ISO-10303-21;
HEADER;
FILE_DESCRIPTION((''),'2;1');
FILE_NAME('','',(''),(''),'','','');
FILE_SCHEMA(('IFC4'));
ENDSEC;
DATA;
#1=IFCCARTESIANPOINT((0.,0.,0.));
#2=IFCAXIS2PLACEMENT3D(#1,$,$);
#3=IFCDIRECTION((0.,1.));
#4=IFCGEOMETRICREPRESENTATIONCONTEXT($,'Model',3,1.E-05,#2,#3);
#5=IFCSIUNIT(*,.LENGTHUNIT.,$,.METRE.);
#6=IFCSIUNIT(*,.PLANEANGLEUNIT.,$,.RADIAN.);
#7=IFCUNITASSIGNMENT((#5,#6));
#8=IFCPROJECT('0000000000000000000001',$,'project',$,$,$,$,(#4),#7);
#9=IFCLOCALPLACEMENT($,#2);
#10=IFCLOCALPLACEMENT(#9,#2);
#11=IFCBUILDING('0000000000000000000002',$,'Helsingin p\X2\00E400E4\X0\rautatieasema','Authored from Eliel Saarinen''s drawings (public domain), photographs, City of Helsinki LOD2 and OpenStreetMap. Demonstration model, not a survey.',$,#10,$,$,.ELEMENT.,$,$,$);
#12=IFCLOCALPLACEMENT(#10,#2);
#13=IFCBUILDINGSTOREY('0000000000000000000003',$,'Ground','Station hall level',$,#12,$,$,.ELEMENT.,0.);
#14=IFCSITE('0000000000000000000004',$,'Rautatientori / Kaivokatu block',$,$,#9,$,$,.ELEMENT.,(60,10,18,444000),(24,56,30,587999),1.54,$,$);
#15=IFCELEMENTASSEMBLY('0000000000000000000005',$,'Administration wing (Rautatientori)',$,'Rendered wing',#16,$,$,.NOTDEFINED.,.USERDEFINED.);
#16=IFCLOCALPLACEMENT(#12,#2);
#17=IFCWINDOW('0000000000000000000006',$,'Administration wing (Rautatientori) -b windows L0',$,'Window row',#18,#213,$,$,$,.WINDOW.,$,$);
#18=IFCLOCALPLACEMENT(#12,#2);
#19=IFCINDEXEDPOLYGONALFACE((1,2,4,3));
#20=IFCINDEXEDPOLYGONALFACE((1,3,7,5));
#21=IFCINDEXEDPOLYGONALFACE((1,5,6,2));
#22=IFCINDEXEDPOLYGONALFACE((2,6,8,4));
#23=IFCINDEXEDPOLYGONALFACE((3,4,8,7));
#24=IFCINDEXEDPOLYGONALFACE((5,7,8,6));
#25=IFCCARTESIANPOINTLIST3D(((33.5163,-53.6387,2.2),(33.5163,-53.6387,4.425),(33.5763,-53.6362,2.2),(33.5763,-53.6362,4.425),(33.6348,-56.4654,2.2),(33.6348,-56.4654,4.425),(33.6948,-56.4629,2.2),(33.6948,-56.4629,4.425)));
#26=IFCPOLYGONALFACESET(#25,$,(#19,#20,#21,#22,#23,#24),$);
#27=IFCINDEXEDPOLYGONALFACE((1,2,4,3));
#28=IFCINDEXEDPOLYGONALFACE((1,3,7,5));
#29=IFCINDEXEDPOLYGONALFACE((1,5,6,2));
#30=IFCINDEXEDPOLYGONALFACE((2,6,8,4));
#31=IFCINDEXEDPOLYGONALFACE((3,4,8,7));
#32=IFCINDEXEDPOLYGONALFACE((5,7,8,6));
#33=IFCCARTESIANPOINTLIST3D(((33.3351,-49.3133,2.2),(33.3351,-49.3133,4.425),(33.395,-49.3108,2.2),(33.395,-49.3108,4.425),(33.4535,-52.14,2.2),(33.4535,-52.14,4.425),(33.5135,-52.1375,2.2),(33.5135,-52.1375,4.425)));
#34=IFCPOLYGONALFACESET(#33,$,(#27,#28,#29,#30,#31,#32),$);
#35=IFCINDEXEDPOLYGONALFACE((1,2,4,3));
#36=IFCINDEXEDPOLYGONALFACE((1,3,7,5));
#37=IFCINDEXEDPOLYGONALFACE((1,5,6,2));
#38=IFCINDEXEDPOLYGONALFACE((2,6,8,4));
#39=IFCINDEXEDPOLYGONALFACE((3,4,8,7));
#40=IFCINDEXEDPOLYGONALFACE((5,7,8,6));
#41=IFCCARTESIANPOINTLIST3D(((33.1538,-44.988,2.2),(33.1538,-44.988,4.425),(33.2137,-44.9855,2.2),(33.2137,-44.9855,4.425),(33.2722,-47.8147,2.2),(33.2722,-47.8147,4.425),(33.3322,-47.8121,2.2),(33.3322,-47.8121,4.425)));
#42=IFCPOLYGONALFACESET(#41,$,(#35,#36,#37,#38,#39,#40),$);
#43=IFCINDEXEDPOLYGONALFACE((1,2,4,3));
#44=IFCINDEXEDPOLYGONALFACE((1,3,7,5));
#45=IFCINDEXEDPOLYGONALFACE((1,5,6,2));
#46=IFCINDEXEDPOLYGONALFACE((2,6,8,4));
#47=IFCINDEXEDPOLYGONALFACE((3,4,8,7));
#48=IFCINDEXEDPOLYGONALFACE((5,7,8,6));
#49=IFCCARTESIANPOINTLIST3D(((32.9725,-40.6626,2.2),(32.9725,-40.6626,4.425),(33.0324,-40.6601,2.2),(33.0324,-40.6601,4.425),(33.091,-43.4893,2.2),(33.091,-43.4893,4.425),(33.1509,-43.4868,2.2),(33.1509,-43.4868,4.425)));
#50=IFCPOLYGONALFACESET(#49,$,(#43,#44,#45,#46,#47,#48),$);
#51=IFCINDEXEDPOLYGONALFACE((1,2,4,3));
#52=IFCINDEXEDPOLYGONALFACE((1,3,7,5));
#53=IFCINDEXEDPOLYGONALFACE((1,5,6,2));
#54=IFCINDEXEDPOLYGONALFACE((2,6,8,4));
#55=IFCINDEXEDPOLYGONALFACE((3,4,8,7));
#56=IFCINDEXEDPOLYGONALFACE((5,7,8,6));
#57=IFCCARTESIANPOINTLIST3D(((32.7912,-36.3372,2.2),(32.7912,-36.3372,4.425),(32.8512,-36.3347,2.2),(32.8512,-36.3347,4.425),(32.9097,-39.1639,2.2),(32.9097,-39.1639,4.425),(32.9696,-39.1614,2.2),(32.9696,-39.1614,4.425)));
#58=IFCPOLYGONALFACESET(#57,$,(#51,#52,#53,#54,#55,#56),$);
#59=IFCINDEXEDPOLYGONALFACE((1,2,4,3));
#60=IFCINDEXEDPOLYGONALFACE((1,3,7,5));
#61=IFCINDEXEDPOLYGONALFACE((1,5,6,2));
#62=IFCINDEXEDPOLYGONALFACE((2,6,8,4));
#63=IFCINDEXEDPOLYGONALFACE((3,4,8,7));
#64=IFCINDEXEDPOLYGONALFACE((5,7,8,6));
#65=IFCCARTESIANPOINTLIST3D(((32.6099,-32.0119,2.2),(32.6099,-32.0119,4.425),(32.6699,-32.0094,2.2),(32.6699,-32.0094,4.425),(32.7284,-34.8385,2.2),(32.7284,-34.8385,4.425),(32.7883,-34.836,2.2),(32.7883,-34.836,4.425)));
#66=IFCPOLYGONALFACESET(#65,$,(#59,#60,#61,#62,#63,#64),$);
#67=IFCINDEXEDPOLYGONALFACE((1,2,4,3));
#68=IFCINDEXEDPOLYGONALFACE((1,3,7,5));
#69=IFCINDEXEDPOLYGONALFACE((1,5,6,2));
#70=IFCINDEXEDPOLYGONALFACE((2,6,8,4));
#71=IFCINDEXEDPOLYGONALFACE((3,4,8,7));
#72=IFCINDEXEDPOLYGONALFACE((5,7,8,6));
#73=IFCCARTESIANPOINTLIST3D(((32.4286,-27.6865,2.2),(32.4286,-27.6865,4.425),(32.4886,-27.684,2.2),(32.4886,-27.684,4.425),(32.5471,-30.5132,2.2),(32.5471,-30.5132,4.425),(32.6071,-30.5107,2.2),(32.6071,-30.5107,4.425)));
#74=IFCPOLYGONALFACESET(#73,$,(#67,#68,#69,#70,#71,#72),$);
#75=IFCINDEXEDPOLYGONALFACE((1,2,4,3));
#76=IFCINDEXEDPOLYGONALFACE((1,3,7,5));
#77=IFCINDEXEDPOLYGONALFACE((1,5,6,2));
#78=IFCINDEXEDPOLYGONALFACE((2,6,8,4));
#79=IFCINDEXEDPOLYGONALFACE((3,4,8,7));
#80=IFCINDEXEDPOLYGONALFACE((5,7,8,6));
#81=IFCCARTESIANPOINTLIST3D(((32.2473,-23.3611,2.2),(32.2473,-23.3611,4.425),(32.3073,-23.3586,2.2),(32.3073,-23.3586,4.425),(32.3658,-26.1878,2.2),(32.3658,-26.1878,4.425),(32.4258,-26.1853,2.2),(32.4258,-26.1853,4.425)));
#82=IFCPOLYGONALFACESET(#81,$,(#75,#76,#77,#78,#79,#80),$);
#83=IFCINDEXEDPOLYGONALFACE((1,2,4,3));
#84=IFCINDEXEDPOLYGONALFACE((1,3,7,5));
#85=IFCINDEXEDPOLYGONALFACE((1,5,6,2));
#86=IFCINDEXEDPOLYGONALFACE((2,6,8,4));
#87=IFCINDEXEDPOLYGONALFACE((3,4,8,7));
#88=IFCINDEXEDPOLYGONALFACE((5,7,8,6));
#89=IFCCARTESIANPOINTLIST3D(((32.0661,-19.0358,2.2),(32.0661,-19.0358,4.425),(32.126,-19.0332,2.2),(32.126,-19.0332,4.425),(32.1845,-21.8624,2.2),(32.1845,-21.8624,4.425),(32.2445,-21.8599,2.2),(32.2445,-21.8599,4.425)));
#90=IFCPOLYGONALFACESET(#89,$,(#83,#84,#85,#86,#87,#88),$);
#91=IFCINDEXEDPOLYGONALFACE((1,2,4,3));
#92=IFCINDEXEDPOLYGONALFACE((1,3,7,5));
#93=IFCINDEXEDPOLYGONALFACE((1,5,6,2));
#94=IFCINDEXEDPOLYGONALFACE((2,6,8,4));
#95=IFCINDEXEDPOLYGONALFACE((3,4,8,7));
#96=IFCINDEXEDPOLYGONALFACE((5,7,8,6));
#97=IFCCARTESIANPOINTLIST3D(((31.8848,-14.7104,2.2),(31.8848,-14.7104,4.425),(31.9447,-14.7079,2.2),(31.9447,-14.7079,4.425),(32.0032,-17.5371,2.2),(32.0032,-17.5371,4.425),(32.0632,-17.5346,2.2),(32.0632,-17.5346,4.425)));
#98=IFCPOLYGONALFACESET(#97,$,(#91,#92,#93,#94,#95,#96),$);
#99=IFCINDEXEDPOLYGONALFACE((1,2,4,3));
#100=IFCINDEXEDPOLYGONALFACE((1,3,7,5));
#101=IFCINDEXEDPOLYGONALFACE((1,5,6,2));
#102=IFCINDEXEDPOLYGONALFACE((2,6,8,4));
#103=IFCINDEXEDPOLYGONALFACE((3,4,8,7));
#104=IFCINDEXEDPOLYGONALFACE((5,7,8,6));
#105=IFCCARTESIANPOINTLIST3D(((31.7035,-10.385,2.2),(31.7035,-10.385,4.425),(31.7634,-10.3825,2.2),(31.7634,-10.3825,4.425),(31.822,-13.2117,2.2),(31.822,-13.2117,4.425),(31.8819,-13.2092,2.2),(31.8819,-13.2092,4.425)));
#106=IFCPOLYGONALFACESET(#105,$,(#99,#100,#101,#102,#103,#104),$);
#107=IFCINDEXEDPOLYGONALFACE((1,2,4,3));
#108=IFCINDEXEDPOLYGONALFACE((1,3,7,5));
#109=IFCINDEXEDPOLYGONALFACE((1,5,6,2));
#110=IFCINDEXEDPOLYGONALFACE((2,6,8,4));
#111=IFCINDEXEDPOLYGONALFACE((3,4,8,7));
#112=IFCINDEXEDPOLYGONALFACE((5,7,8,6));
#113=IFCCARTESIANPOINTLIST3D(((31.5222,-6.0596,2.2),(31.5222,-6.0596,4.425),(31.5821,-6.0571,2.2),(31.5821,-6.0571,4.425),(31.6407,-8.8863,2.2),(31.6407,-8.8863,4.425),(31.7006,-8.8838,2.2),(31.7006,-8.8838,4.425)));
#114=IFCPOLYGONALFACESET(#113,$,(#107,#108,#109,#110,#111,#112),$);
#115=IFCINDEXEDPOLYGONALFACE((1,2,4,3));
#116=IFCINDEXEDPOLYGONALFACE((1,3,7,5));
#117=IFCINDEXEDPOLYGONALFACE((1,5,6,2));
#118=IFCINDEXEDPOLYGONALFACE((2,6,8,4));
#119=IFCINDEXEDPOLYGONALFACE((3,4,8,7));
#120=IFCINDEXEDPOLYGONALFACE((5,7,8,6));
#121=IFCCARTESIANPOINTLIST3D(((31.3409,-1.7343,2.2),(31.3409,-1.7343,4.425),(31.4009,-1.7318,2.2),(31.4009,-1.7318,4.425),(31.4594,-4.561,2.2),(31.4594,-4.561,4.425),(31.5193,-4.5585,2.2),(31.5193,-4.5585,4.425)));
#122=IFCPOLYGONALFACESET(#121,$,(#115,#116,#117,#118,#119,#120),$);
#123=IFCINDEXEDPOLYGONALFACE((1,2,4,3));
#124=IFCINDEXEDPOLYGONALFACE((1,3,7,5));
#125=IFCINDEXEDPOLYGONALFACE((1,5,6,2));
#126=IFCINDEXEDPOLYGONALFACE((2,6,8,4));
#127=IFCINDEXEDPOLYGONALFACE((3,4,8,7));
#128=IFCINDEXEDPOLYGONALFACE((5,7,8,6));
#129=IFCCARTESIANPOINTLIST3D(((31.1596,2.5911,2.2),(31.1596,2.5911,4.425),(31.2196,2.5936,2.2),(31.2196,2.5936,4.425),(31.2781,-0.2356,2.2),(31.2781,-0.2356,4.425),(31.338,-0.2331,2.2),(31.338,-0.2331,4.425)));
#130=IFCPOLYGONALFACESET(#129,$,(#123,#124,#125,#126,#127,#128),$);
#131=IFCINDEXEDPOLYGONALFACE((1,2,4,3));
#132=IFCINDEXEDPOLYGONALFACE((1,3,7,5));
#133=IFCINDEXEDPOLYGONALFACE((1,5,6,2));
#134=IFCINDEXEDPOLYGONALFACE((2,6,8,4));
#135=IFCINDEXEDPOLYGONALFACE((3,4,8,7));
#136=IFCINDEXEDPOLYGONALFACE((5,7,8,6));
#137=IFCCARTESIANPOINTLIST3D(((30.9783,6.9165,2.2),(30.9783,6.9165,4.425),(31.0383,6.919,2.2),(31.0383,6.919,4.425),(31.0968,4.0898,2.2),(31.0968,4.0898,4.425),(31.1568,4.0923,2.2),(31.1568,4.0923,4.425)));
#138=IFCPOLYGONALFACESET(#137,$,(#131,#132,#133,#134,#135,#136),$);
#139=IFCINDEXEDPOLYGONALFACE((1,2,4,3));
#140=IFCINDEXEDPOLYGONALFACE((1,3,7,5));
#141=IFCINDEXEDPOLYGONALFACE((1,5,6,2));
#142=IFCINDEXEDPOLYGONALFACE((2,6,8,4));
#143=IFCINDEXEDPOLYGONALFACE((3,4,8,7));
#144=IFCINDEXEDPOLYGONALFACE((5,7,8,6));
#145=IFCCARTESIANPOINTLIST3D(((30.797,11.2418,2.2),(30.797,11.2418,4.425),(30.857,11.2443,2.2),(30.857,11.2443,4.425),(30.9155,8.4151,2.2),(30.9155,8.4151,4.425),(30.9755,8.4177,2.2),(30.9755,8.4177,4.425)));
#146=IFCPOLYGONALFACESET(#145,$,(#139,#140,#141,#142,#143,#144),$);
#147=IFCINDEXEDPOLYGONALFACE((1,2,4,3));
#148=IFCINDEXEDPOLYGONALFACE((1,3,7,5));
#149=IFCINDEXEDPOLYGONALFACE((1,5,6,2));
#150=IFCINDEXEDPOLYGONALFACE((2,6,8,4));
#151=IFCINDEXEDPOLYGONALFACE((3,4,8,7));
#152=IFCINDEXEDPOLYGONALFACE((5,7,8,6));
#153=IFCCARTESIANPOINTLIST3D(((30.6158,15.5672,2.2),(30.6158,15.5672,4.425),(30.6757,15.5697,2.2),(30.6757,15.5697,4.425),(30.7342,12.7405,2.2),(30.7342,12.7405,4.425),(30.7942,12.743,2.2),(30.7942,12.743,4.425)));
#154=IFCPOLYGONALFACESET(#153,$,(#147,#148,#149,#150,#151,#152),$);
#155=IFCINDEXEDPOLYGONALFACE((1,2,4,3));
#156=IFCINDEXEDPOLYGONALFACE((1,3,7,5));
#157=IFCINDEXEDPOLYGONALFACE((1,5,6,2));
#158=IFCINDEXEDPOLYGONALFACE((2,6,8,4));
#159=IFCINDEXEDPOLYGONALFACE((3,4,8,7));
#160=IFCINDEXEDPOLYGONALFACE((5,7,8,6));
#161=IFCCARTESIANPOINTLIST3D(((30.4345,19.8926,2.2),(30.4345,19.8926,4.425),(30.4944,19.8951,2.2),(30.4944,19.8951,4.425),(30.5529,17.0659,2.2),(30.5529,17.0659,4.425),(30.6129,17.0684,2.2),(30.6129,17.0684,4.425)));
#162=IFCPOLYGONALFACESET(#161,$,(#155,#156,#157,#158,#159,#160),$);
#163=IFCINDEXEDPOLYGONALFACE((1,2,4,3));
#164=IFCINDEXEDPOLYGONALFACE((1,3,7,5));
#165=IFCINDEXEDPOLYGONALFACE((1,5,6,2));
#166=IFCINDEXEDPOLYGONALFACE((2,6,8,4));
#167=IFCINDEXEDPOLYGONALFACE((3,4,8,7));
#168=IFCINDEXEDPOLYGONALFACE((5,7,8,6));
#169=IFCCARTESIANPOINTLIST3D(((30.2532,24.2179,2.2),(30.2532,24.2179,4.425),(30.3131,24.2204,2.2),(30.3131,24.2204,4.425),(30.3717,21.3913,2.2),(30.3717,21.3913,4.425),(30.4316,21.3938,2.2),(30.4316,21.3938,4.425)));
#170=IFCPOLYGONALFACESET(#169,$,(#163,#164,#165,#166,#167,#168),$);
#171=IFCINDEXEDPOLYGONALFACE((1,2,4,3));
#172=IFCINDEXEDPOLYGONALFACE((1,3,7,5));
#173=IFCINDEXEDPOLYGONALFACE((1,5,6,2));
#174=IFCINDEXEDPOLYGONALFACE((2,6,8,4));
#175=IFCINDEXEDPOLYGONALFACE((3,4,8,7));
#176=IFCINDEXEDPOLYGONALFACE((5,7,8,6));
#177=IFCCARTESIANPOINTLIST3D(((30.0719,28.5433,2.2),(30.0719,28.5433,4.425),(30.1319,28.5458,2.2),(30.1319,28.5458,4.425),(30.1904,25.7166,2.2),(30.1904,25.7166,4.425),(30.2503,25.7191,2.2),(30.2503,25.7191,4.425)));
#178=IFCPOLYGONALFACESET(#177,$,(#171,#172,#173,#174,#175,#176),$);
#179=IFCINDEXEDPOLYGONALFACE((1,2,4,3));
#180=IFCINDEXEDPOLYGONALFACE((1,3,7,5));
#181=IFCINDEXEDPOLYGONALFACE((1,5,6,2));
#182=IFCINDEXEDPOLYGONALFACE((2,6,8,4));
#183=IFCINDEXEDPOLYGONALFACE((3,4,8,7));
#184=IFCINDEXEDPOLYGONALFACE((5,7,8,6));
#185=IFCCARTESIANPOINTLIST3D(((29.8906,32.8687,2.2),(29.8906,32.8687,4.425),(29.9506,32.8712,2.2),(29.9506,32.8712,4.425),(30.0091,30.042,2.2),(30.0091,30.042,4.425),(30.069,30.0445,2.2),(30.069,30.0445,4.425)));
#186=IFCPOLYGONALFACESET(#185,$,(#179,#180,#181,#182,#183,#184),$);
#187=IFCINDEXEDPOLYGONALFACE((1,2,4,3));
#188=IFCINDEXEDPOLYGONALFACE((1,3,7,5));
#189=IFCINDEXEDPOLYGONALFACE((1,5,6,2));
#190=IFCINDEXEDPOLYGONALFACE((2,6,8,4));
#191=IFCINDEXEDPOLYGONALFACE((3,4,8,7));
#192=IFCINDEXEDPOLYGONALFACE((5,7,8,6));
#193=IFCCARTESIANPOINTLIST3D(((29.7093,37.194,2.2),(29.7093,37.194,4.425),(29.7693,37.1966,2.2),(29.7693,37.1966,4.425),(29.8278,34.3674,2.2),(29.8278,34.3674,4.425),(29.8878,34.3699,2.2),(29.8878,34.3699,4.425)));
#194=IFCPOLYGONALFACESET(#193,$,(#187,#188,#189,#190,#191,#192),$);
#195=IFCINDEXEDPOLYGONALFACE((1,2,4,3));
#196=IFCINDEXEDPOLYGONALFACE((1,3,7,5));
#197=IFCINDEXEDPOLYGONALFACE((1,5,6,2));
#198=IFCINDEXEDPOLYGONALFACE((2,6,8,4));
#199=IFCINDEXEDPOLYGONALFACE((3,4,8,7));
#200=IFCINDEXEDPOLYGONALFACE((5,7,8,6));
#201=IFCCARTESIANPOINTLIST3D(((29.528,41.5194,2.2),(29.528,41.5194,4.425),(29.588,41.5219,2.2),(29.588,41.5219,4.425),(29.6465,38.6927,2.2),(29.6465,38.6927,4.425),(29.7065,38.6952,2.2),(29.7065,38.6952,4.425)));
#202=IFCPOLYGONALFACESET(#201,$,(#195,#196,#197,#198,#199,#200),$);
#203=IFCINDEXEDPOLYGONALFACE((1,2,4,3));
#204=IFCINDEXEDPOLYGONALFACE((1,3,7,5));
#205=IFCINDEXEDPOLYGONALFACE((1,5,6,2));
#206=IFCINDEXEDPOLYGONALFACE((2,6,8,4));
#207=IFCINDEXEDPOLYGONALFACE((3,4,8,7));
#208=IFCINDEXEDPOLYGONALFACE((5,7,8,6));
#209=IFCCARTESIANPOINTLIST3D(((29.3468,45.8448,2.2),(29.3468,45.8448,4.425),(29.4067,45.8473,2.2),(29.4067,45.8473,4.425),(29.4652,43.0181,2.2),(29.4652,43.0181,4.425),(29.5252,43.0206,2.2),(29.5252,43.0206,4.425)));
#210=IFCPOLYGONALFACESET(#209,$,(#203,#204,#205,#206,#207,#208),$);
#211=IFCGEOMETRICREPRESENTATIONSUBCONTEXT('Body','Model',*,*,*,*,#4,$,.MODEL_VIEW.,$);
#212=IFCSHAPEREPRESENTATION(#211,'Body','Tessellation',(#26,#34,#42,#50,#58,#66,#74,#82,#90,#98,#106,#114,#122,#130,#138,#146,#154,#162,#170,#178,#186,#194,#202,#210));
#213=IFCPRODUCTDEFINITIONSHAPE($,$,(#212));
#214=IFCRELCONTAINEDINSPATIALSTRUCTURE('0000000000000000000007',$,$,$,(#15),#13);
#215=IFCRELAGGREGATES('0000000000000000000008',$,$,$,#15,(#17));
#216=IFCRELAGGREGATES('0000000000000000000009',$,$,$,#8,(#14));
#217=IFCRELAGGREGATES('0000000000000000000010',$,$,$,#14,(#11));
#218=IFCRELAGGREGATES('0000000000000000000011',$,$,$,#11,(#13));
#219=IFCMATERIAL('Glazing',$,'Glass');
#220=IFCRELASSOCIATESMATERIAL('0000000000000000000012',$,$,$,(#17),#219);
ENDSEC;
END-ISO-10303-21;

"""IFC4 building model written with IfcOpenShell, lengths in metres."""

from ifc_helpers import new_model, si_unit, direction, frame, frame_2d, origin, place, context, subcontext, project, spatial, rectangle, extrude, material, element, aggregate, save


model = new_model("IFC4")

# Units and contexts
model_context = context("Model", 3, precision=1e-05, world=origin(), true_north=direction((0.0, 1.0)))
body_context = subcontext(model_context, "Body", "Model", "MODEL_VIEW")
ifc_project = project(units=[si_unit("LENGTHUNIT", "METRE"), si_unit("PLANEANGLEUNIT", "RADIAN")], contexts=[model_context])

# Site, building, storey
site_placement = place(None, origin())
site = spatial("IfcSite", under=ifc_project, at=site_placement, Name="Rautatientori / Kaivokatu block", CompositionType="ELEMENT", RefLatitude=(60, 10, 18, 444000), RefLongitude=(24, 56, 30, 587999), RefElevation=1.54)
building_placement = place(site_placement, origin())
building = spatial("IfcBuilding", under=site, at=building_placement, Name="Helsingin päärautatieasema", Description="Authored from Eliel Saarinen's drawings (public domain), photographs, City of Helsinki LOD2 and OpenStreetMap. Demonstration model, not a survey.", CompositionType="ELEMENT")
storey_placement = place(building_placement, origin())
storey = spatial("IfcBuildingStorey", under=building, at=storey_placement, Name="Ground", Description="Station hall level", CompositionType="ELEMENT", Elevation=0.0)

# Element assembly, window
assembly_placement = place(building_placement, origin())
assembly = element("IfcElementAssembly", 1, at=assembly_placement, inside=storey, Name="Administration wing (Rautatientori)", ObjectType="Rendered wing", AssemblyPlace="NOTDEFINED", PredefinedType="USERDEFINED")
ifc_material_1 = material(Name="Glazing", Category="Glass")
window_1_placement = place(building_placement, origin())
window_1 = element("IfcWindow", 2, at=window_1_placement, material=ifc_material_1, Name="Administration wing (Rautatientori) -b windows L0", ObjectType="Window row", PredefinedType="WINDOW", context=body_context, shape_type="SweptSolid", body=[
    extrude(rectangle(XDim=2.8292, YDim=0.06, at=frame_2d((0.0, 0.0), x_axis=(-0.041876, 0.999123))), frame((33.6056, -55.0508, 2.2)), (0.0, 0.0, 1.0), 2.225),
    extrude(rectangle(XDim=2.8292, YDim=0.06, at=frame_2d((0.0, 0.0), x_axis=(-0.041876, 0.999123))), frame((33.4243, -50.7254, 2.2)), (0.0, 0.0, 1.0), 2.225),
    extrude(rectangle(XDim=2.8292, YDim=0.06, at=frame_2d((0.0, 0.0), x_axis=(-0.041876, 0.999123))), frame((33.243, -46.4001, 2.2)), (0.0, 0.0, 1.0), 2.225),
    extrude(rectangle(XDim=2.8292, YDim=0.06, at=frame_2d((0.0, 0.0), x_axis=(-0.041876, 0.999123))), frame((33.0617, -42.0747, 2.2)), (0.0, 0.0, 1.0), 2.225),
    extrude(rectangle(XDim=2.8292, YDim=0.06, at=frame_2d((0.0, 0.0), x_axis=(-0.041876, 0.999123))), frame((32.8804, -37.7493, 2.2)), (0.0, 0.0, 1.0), 2.225),
    extrude(rectangle(XDim=2.8292, YDim=0.06, at=frame_2d((0.0, 0.0), x_axis=(-0.041876, 0.999123))), frame((32.6991, -33.4239, 2.2)), (0.0, 0.0, 1.0), 2.225),
    extrude(rectangle(XDim=2.8292, YDim=0.06, at=frame_2d((0.0, 0.0), x_axis=(-0.041876, 0.999123))), frame((32.5178, -29.0986, 2.2)), (0.0, 0.0, 1.0), 2.225),
    extrude(rectangle(XDim=2.8292, YDim=0.06, at=frame_2d((0.0, 0.0), x_axis=(-0.041876, 0.999123))), frame((32.3366, -24.7732, 2.2)), (0.0, 0.0, 1.0), 2.225),
    extrude(rectangle(XDim=2.8292, YDim=0.06, at=frame_2d((0.0, 0.0), x_axis=(-0.041876, 0.999123))), frame((32.1553, -20.4478, 2.2)), (0.0, 0.0, 1.0), 2.225),
    extrude(rectangle(XDim=2.8292, YDim=0.06, at=frame_2d((0.0, 0.0), x_axis=(-0.041876, 0.999123))), frame((31.974, -16.1225, 2.2)), (0.0, 0.0, 1.0), 2.225),
    extrude(rectangle(XDim=2.8292, YDim=0.06, at=frame_2d((0.0, 0.0), x_axis=(-0.041876, 0.999123))), frame((31.7927, -11.7971, 2.2)), (0.0, 0.0, 1.0), 2.225),
    extrude(rectangle(XDim=2.8292, YDim=0.06, at=frame_2d((0.0, 0.0), x_axis=(-0.041876, 0.999123))), frame((31.6114, -7.4717, 2.2)), (0.0, 0.0, 1.0), 2.225),
    extrude(rectangle(XDim=2.8292, YDim=0.06, at=frame_2d((0.0, 0.0), x_axis=(-0.041876, 0.999123))), frame((31.4301, -3.1464, 2.2)), (0.0, 0.0, 1.0), 2.225),
    extrude(rectangle(XDim=2.8292, YDim=0.06, at=frame_2d((0.0, 0.0), x_axis=(-0.041876, 0.999123))), frame((31.2488, 1.179, 2.2)), (0.0, 0.0, 1.0), 2.225),
    extrude(rectangle(XDim=2.8292, YDim=0.06, at=frame_2d((0.0, 0.0), x_axis=(-0.041876, 0.999123))), frame((31.0675, 5.5044, 2.2)), (0.0, 0.0, 1.0), 2.225),
    extrude(rectangle(XDim=2.8292, YDim=0.06, at=frame_2d((0.0, 0.0), x_axis=(-0.041876, 0.999123))), frame((30.8863, 9.8297, 2.2)), (0.0, 0.0, 1.0), 2.225),
    extrude(rectangle(XDim=2.8292, YDim=0.06, at=frame_2d((0.0, 0.0), x_axis=(-0.041876, 0.999123))), frame((30.705, 14.1551, 2.2)), (0.0, 0.0, 1.0), 2.225),
    extrude(rectangle(XDim=2.8292, YDim=0.06, at=frame_2d((0.0, 0.0), x_axis=(-0.041876, 0.999123))), frame((30.5237, 18.4805, 2.2)), (0.0, 0.0, 1.0), 2.225),
    extrude(rectangle(XDim=2.8292, YDim=0.06, at=frame_2d((0.0, 0.0), x_axis=(-0.041876, 0.999123))), frame((30.3424, 22.8059, 2.2)), (0.0, 0.0, 1.0), 2.225),
    extrude(rectangle(XDim=2.8292, YDim=0.06, at=frame_2d((0.0, 0.0), x_axis=(-0.041876, 0.999123))), frame((30.1611, 27.1312, 2.2)), (0.0, 0.0, 1.0), 2.225),
    extrude(rectangle(XDim=2.8292, YDim=0.06, at=frame_2d((0.0, 0.0), x_axis=(-0.041876, 0.999123))), frame((29.9798, 31.4566, 2.2)), (0.0, 0.0, 1.0), 2.225),
    extrude(rectangle(XDim=2.8292, YDim=0.06, at=frame_2d((0.0, 0.0), x_axis=(-0.041876, 0.999123))), frame((29.7985, 35.782, 2.2)), (0.0, 0.0, 1.0), 2.225),
    extrude(rectangle(XDim=2.8292, YDim=0.06, at=frame_2d((0.0, 0.0), x_axis=(-0.041876, 0.999123))), frame((29.6173, 40.1073, 2.2)), (0.0, 0.0, 1.0), 2.225),
    extrude(rectangle(XDim=2.8292, YDim=0.06, at=frame_2d((0.0, 0.0), x_axis=(-0.041876, 0.999123))), frame((29.436, 44.4327, 2.2)), (0.0, 0.0, 1.0), 2.225),
])
aggregate(assembly, [window_1])

save(model, "model.ifc")
